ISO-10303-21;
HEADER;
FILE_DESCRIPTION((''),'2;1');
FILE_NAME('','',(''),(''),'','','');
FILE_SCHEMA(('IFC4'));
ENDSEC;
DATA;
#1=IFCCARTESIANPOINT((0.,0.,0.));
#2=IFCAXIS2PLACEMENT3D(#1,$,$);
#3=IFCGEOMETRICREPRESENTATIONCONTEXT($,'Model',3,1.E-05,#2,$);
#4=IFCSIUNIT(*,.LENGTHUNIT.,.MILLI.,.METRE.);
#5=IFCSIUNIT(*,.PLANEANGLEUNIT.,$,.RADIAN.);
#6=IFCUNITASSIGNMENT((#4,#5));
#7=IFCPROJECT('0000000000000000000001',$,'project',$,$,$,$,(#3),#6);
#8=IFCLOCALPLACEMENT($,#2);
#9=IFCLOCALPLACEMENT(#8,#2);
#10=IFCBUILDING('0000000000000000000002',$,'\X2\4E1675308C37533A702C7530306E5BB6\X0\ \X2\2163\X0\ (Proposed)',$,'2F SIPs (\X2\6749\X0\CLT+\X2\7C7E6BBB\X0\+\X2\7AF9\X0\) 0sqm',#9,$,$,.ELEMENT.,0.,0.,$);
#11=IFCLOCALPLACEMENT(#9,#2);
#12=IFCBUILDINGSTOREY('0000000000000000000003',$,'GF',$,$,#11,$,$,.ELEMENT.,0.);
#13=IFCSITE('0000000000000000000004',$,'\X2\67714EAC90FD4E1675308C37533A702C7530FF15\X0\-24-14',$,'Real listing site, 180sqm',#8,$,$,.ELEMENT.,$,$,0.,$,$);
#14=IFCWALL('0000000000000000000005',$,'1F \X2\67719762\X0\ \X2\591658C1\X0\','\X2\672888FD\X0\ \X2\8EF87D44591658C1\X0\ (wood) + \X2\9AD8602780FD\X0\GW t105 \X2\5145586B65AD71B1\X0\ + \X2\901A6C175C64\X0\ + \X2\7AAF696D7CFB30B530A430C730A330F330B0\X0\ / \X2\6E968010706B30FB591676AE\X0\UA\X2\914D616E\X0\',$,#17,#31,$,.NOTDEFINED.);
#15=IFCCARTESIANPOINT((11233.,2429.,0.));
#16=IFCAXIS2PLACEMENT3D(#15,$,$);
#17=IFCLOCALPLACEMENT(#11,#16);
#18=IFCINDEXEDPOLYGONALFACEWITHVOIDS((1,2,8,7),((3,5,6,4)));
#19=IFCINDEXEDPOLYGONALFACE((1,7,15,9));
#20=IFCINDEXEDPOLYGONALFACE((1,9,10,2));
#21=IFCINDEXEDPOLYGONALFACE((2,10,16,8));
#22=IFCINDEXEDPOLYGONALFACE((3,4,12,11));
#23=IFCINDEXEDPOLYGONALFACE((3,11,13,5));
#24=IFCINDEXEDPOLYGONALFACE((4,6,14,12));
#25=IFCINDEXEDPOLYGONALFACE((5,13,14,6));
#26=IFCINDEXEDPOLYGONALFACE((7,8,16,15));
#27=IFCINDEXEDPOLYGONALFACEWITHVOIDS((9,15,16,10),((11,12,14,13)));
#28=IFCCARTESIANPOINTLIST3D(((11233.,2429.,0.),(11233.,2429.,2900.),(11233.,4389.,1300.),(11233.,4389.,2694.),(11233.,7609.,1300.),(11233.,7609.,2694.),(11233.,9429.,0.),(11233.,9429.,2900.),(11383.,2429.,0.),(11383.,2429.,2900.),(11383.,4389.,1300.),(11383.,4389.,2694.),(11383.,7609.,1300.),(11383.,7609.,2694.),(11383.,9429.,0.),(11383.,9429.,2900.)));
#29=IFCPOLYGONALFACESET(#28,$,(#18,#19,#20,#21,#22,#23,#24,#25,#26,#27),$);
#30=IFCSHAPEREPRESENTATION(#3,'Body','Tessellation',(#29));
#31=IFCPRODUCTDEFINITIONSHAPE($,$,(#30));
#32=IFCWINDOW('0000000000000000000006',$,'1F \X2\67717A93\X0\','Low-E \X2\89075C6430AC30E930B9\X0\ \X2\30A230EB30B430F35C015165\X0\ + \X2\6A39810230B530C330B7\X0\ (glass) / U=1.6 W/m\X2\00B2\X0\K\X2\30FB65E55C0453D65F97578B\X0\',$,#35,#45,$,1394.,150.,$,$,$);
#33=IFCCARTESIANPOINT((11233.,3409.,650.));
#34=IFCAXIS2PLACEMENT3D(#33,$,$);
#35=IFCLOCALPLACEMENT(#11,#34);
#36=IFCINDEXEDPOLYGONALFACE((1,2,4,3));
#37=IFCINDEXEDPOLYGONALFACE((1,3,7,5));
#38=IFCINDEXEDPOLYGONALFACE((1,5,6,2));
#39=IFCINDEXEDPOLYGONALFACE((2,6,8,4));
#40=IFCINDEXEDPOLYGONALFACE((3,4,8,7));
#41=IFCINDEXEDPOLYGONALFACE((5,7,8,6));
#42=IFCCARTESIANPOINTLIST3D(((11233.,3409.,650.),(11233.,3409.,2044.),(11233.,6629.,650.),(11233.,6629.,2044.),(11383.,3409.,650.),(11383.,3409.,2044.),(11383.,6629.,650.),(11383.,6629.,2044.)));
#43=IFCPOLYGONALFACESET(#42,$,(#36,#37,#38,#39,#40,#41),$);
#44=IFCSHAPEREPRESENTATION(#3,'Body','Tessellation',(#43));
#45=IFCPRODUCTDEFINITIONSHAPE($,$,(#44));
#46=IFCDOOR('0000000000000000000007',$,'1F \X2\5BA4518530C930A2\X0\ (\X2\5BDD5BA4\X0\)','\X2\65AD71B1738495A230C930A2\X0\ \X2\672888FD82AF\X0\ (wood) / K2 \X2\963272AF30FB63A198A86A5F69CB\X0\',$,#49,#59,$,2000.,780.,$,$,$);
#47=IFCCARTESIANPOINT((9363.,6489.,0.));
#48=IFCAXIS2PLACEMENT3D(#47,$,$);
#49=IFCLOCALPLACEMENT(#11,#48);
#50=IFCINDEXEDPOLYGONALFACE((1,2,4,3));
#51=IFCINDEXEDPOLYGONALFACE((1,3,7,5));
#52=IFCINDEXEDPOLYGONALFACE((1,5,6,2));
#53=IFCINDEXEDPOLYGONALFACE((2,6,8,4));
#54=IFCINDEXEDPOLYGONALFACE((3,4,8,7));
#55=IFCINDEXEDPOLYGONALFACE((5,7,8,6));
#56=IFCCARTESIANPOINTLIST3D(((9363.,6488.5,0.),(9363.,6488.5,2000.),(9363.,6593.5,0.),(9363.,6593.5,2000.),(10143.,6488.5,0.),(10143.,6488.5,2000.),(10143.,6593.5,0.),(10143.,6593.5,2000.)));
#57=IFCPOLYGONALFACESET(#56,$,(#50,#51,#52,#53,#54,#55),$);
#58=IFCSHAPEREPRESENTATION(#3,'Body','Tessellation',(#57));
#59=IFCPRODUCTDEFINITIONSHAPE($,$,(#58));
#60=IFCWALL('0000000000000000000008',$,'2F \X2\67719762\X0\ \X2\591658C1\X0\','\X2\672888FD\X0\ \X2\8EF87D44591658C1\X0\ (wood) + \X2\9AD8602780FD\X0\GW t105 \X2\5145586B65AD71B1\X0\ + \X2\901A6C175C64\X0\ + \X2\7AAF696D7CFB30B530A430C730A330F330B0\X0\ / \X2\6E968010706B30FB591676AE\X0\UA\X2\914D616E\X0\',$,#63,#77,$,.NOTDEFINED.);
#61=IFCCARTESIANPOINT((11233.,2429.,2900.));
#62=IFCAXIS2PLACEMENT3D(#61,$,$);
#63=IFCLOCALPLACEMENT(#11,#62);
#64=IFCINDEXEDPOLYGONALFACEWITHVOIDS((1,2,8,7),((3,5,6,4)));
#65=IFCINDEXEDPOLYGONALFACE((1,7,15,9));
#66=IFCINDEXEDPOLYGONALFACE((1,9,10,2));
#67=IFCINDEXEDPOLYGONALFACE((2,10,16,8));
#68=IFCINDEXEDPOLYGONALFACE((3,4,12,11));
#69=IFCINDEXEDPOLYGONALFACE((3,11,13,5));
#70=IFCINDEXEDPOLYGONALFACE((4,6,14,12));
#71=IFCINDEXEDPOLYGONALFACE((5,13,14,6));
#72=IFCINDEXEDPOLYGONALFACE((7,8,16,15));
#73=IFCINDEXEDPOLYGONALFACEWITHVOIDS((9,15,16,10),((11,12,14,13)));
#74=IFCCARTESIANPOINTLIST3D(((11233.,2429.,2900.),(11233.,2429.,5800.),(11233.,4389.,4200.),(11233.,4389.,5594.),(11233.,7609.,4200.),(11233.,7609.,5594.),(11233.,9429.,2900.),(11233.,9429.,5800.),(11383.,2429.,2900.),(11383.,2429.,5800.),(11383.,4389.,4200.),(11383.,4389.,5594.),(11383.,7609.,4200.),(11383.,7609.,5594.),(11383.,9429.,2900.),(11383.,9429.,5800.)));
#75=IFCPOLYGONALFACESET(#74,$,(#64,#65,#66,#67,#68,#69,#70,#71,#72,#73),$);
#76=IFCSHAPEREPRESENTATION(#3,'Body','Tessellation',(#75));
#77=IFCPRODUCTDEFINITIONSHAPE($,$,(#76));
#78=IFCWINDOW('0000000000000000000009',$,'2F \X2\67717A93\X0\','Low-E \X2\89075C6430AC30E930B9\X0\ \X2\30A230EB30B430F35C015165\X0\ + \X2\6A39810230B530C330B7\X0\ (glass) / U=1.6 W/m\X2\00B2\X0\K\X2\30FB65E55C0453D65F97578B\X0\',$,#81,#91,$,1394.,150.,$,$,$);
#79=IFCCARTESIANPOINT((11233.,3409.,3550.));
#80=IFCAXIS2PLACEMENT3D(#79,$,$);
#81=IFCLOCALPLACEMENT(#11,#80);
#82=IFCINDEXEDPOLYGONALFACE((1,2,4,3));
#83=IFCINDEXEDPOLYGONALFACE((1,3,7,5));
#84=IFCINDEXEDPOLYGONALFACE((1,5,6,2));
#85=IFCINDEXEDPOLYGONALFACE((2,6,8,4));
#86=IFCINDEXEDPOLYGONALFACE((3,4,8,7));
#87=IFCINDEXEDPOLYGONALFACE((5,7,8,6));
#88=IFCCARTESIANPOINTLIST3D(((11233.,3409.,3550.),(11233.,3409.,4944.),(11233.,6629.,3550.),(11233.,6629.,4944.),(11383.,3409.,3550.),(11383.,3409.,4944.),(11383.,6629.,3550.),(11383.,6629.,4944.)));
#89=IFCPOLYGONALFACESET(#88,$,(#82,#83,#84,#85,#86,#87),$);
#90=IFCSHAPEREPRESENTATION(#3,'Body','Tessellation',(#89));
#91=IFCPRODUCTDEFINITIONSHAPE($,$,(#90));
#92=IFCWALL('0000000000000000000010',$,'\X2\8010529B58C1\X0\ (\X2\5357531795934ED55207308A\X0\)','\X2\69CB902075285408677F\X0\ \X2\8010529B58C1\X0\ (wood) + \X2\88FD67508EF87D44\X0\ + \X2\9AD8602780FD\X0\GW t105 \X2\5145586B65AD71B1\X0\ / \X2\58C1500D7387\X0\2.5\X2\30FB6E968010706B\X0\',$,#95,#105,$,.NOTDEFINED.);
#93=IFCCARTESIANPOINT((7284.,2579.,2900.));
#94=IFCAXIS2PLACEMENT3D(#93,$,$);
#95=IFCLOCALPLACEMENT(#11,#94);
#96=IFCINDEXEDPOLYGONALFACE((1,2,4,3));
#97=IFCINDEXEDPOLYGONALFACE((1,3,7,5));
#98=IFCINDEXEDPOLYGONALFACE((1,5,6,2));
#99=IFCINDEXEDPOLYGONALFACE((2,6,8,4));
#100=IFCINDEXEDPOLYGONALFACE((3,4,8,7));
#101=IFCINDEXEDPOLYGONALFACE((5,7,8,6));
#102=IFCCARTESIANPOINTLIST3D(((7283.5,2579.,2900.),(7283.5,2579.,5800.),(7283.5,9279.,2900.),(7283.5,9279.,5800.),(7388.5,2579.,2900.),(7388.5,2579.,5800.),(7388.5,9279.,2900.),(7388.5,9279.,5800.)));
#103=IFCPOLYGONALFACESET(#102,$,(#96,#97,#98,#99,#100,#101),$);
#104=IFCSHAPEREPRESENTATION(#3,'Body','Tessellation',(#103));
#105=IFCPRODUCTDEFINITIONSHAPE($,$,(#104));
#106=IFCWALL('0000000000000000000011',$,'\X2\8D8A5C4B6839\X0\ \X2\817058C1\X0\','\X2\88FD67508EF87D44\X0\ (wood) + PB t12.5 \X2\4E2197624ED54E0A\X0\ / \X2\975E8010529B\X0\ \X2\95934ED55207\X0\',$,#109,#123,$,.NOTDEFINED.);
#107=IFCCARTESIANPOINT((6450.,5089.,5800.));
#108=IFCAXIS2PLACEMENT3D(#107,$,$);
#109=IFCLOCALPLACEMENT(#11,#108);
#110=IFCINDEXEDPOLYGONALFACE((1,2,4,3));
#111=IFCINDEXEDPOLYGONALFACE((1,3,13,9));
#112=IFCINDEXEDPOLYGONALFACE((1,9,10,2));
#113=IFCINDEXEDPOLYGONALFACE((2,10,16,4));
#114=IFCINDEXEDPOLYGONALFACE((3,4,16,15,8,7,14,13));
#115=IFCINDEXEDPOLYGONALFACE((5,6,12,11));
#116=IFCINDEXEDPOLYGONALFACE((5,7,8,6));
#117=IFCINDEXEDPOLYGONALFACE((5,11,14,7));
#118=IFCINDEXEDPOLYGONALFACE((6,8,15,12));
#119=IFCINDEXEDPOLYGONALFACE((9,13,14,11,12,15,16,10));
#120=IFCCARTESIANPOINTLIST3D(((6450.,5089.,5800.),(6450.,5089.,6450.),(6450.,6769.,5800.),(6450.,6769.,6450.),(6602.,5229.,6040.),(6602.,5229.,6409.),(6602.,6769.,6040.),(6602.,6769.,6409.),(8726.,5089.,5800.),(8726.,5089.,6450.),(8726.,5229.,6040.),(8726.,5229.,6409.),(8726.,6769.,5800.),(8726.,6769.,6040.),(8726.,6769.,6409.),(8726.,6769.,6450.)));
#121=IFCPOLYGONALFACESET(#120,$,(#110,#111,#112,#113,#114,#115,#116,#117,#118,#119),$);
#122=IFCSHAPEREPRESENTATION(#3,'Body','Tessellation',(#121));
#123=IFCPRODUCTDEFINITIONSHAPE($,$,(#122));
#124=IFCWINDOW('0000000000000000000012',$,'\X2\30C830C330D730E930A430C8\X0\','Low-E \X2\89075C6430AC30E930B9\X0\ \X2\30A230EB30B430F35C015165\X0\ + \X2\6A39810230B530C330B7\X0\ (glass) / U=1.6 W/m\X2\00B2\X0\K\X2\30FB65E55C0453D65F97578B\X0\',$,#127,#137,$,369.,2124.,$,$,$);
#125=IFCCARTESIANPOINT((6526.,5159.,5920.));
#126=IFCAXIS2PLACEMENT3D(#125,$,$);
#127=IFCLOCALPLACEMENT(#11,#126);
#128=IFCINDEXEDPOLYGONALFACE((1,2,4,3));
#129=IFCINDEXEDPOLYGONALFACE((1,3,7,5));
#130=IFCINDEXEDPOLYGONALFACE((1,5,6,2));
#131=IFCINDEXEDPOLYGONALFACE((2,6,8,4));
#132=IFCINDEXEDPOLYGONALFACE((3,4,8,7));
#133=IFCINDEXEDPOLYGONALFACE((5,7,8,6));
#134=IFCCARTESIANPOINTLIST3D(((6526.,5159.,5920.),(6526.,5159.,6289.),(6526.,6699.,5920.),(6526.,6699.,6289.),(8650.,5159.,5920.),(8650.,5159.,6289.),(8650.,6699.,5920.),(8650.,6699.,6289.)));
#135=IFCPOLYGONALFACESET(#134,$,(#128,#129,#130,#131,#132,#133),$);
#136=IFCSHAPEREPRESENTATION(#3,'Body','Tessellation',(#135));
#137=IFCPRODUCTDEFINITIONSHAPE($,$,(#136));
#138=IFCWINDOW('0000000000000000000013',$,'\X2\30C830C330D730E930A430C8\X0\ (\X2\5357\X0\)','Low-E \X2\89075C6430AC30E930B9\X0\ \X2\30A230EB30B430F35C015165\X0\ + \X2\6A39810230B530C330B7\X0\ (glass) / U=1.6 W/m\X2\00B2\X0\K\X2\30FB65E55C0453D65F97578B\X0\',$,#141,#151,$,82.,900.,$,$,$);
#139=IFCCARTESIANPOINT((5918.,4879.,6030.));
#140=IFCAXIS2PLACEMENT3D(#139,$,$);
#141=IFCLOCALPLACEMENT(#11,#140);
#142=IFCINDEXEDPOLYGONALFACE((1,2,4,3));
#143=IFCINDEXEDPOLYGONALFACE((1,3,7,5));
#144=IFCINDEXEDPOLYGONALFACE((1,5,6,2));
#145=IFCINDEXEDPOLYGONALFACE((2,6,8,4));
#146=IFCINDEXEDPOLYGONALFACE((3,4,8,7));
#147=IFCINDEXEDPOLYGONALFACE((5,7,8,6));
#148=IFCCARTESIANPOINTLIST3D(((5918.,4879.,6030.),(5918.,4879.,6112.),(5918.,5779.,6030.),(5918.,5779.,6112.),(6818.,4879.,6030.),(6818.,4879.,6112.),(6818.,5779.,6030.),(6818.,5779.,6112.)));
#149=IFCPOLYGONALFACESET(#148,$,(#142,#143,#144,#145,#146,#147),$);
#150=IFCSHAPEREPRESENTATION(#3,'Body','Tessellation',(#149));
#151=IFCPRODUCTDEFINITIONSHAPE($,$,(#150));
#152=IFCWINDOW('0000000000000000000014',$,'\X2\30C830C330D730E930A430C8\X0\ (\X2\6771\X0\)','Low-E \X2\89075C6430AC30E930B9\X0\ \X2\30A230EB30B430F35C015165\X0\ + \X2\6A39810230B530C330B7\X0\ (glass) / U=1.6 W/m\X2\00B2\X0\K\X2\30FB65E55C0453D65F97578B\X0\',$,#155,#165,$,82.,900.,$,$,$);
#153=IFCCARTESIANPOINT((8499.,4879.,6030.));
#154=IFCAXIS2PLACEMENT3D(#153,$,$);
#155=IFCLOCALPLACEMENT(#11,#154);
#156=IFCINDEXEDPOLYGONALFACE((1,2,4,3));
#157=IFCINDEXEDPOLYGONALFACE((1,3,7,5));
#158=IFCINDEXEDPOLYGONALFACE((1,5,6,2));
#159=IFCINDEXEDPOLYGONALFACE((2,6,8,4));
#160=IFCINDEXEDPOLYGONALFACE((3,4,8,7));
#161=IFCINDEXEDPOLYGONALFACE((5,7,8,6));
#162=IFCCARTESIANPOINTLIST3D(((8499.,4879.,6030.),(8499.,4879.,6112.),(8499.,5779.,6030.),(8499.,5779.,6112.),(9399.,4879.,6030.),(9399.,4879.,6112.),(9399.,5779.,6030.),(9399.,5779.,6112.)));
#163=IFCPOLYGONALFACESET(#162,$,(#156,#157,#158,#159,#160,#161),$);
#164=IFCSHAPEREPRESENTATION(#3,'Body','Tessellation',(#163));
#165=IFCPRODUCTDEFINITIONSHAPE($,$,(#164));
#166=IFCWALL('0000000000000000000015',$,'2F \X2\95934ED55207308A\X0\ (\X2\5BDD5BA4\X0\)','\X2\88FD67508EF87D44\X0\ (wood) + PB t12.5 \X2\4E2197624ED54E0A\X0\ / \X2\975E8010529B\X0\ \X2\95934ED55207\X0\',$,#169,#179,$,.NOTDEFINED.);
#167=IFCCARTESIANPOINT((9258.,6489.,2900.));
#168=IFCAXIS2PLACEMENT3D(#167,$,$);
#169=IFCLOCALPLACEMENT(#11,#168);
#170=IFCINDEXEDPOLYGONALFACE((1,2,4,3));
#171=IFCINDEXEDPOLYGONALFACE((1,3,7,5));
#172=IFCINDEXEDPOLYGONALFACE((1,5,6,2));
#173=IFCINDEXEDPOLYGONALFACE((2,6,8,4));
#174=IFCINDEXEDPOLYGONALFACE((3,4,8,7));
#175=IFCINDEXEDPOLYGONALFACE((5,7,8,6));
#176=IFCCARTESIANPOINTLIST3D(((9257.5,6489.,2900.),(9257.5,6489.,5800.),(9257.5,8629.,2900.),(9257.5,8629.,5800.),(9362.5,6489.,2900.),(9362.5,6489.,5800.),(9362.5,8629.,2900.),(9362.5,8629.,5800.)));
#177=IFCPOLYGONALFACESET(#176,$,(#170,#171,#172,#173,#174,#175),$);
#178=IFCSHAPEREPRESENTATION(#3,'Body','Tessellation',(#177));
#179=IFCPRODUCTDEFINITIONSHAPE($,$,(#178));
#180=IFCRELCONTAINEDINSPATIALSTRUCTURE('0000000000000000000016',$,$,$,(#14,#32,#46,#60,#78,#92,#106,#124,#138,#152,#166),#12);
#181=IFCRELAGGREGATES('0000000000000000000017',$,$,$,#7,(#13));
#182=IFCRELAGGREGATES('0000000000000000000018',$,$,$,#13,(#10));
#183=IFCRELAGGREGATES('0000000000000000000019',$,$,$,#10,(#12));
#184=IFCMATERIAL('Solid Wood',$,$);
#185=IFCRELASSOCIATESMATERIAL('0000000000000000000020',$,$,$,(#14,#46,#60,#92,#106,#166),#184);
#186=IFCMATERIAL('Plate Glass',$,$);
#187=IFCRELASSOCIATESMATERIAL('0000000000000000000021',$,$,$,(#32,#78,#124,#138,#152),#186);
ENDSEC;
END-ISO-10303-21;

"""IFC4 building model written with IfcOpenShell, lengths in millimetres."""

from ifc_helpers import new_model, si_unit, frame, frame_2d, origin, place, context, project, spatial, rectangle, extrude, material, element, fill, save


model = new_model("IFC4")

# Units and contexts
model_context = context("Model", 3, precision=1e-05, world=origin())
ifc_project = project(units=[si_unit("LENGTHUNIT", "METRE", prefix="MILLI"), si_unit("PLANEANGLEUNIT", "RADIAN")], contexts=[model_context])

# Site, building, storey
site_placement = place(None, origin())
site = spatial("IfcSite", under=ifc_project, at=site_placement, Name="東京都世田谷区瀬田５-24-14", ObjectType="Real listing site, 180sqm", CompositionType="ELEMENT", RefElevation=0.0)
building_placement = place(site_placement, origin())
building = spatial("IfcBuilding", under=site, at=building_placement, Name="世田谷区瀬田の家 Ⅳ (Proposed)", ObjectType="2F SIPs (杉CLT+籾殻+竹) 0sqm", CompositionType="ELEMENT", ElevationOfRefHeight=0.0, ElevationOfTerrain=0.0)
storey_placement = place(building_placement, origin())
storey = spatial("IfcBuildingStorey", under=building, at=storey_placement, Name="GF", CompositionType="ELEMENT", Elevation=0.0)

# Wall, opening, window
ifc_material_1 = material(Name="Solid Wood")
wall_1_placement = place(storey_placement, frame((11233.0, 2429.0, 0.0)))
wall_1 = element("IfcWall", 1, at=wall_1_placement, inside=storey, material=ifc_material_1, Name="1F 東面 外壁", Description="木製 軸組外壁 (wood) + 高性能GW t105 充填断熱 + 通気層 + 窯業系サイディング / 準耐火・外皮UA配慮", PredefinedType="NOTDEFINED", context=model_context, shape_type="SweptSolid", body=[
    extrude(rectangle(XDim=150.0, YDim=7000.0, at=frame_2d((75.0, 3500.0))), frame((11233.0, 2429.0, 0.0)), (0.0, 0.0, 1.0), 2900.0),
])
opening_1_placement = place(storey_placement, frame((11233.0, 3409.0, 650.0)))
opening_1 = element("IfcOpeningElement", 2, at=opening_1_placement, cuts=wall_1, PredefinedType="NOTDEFINED", context=model_context, shape_type="SweptSolid", body=[
    extrude(rectangle(XDim=150.0, YDim=3220.0, at=frame_2d((75.0, 1610.0))), frame((11233.0, 3409.0, 650.0)), (0.0, 0.0, 1.0), 1394.0),
])
ifc_material_2 = material(Name="Plate Glass")
window_1_placement = place(storey_placement, frame((11233.0, 3409.0, 650.0)))
window_1 = element("IfcWindow", 3, at=window_1_placement, inside=storey, material=ifc_material_2, Name="1F 東窓", Description="Low-E 複層ガラス アルゴン封入 + 樹脂サッシ (glass) / U=1.6 W/m²K・日射取得型", OverallHeight=1394.0, OverallWidth=150.0, context=model_context, shape_type="SweptSolid", body=[
    extrude(rectangle(XDim=150.0, YDim=3220.0, at=frame_2d((75.0, 1610.0))), frame((11233.0, 3409.0, 650.0)), (0.0, 0.0, 1.0), 1394.0),
])
fill(opening_1, window_1)

# Door
door_1_placement = place(storey_placement, frame((9363.0, 6489.0, 0.0)))
element("IfcDoor", 4, at=door_1_placement, inside=storey, material=ifc_material_1, Name="1F 室内ドア (寝室)", Description="断熱玄関ドア 木製芯 (wood) / K2 防犯・採風機構", OverallHeight=2000.0, OverallWidth=780.0, context=model_context, shape_type="SweptSolid", body=[
    extrude(rectangle(XDim=780.0, YDim=105.0, at=frame_2d((390.0, 52.0))), frame((9363.0, 6489.0, 0.0)), (0.0, 0.0, 1.0), 2000.0),
])

# Wall, opening, window
wall_2_placement = place(storey_placement, frame((11233.0, 2429.0, 2900.0)))
wall_2 = element("IfcWall", 5, at=wall_2_placement, inside=storey, material=ifc_material_1, Name="2F 東面 外壁", Description="木製 軸組外壁 (wood) + 高性能GW t105 充填断熱 + 通気層 + 窯業系サイディング / 準耐火・外皮UA配慮", PredefinedType="NOTDEFINED", context=model_context, shape_type="SweptSolid", body=[
    extrude(rectangle(XDim=150.0, YDim=7000.0, at=frame_2d((75.0, 3500.0))), frame((11233.0, 2429.0, 2900.0)), (0.0, 0.0, 1.0), 2900.0),
])
opening_2_placement = place(storey_placement, frame((11233.0, 3409.0, 3550.0)))
opening_2 = element("IfcOpeningElement", 6, at=opening_2_placement, cuts=wall_2, PredefinedType="NOTDEFINED", context=model_context, shape_type="SweptSolid", body=[
    extrude(rectangle(XDim=150.0, YDim=3220.0, at=frame_2d((75.0, 1610.0))), frame((11233.0, 3409.0, 3550.0)), (0.0, 0.0, 1.0), 1394.0),
])
window_2_placement = place(storey_placement, frame((11233.0, 3409.0, 3550.0)))
window_2 = element("IfcWindow", 7, at=window_2_placement, inside=storey, material=ifc_material_2, Name="2F 東窓", Description="Low-E 複層ガラス アルゴン封入 + 樹脂サッシ (glass) / U=1.6 W/m²K・日射取得型", OverallHeight=1394.0, OverallWidth=150.0, context=model_context, shape_type="SweptSolid", body=[
    extrude(rectangle(XDim=150.0, YDim=3220.0, at=frame_2d((75.0, 1610.0))), frame((11233.0, 3409.0, 3550.0)), (0.0, 0.0, 1.0), 1394.0),
])
fill(opening_2, window_2)

# Wall
wall_3_placement = place(storey_placement, frame((7284.0, 2579.0, 2900.0)))
element("IfcWall", 8, at=wall_3_placement, inside=storey, material=ifc_material_1, Name="耐力壁 (南北間仕切り)", Description="構造用合板 耐力壁 (wood) + 製材軸組 + 高性能GW t105 充填断熱 / 壁倍率2.5・準耐火", PredefinedType="NOTDEFINED", context=model_context, shape_type="SweptSolid", body=[
    extrude(rectangle(XDim=105.0, YDim=6700.0, at=frame_2d((52.0, 3350.0))), frame((7284.0, 2579.0, 2900.0)), (0.0, 0.0, 1.0), 2900.0),
])

# Wall, openings, windows
wall_4_placement = place(storey_placement, frame((6450.0, 5089.0, 5800.0)))
wall_4 = element("IfcWall", 9, at=wall_4_placement, inside=storey, material=ifc_material_1, Name="越屋根 腰壁", Description="製材軸組 (wood) + PB t12.5 両面仕上 / 非耐力 間仕切", PredefinedType="NOTDEFINED", context=model_context, shape_type="SweptSolid", body=[
    extrude(rectangle(XDim=2276.0, YDim=1680.0, at=frame_2d((1138.0, 840.0))), frame((6450.0, 5089.0, 5800.0)), (0.0, 0.0, 1.0), 650.0),
])
opening_3_placement = place(storey_placement, frame((6526.0, 5159.0, 5920.0)))
opening_3 = element("IfcOpeningElement", 10, at=opening_3_placement, cuts=wall_4, PredefinedType="NOTDEFINED", context=model_context, shape_type="SweptSolid", body=[
    extrude(rectangle(XDim=2124.0, YDim=1540.0, at=frame_2d((1062.0, 770.0))), frame((6526.0, 5159.0, 5920.0)), (0.0, 0.0, 1.0), 369.0),
])
opening_4_placement = place(storey_placement, frame((5918.0, 4879.0, 6030.0)))
opening_4 = element("IfcOpeningElement", 11, at=opening_4_placement, cuts=wall_4, PredefinedType="NOTDEFINED", context=model_context, shape_type="SweptSolid", body=[
    extrude(rectangle(XDim=900.0, YDim=900.0, at=frame_2d((450.0, 450.0))), frame((5918.0, 4879.0, 6030.0)), (0.0, 0.0, 1.0), 82.0),
])
opening_5_placement = place(storey_placement, frame((8499.0, 4879.0, 6030.0)))
opening_5 = element("IfcOpeningElement", 12, at=opening_5_placement, cuts=wall_4, PredefinedType="NOTDEFINED", context=model_context, shape_type="SweptSolid", body=[
    extrude(rectangle(XDim=900.0, YDim=900.0, at=frame_2d((450.0, 450.0))), frame((8499.0, 4879.0, 6030.0)), (0.0, 0.0, 1.0), 82.0),
])
window_3_placement = place(storey_placement, frame((6526.0, 5159.0, 5920.0)))
window_3 = element("IfcWindow", 13, at=window_3_placement, inside=storey, material=ifc_material_2, Name="トップライト", Description="Low-E 複層ガラス アルゴン封入 + 樹脂サッシ (glass) / U=1.6 W/m²K・日射取得型", OverallHeight=369.0, OverallWidth=2124.0, context=model_context, shape_type="SweptSolid", body=[
    extrude(rectangle(XDim=2124.0, YDim=1540.0, at=frame_2d((1062.0, 770.0))), frame((6526.0, 5159.0, 5920.0)), (0.0, 0.0, 1.0), 369.0),
])
fill(opening_3, window_3)
window_4_placement = place(storey_placement, frame((5918.0, 4879.0, 6030.0)))
window_4 = element("IfcWindow", 14, at=window_4_placement, inside=storey, material=ifc_material_2, Name="トップライト (南)", Description="Low-E 複層ガラス アルゴン封入 + 樹脂サッシ (glass) / U=1.6 W/m²K・日射取得型", OverallHeight=82.0, OverallWidth=900.0, context=model_context, shape_type="SweptSolid", body=[
    extrude(rectangle(XDim=900.0, YDim=900.0, at=frame_2d((450.0, 450.0))), frame((5918.0, 4879.0, 6030.0)), (0.0, 0.0, 1.0), 82.0),
])
fill(opening_4, window_4)
window_5_placement = place(storey_placement, frame((8499.0, 4879.0, 6030.0)))
window_5 = element("IfcWindow", 15, at=window_5_placement, inside=storey, material=ifc_material_2, Name="トップライト (東)", Description="Low-E 複層ガラス アルゴン封入 + 樹脂サッシ (glass) / U=1.6 W/m²K・日射取得型", OverallHeight=82.0, OverallWidth=900.0, context=model_context, shape_type="SweptSolid", body=[
    extrude(rectangle(XDim=900.0, YDim=900.0, at=frame_2d((450.0, 450.0))), frame((8499.0, 4879.0, 6030.0)), (0.0, 0.0, 1.0), 82.0),
])
fill(opening_5, window_5)

# Wall
wall_5_placement = place(storey_placement, frame((9258.0, 6489.0, 2900.0)))
element("IfcWall", 16, at=wall_5_placement, inside=storey, material=ifc_material_1, Name="2F 間仕切り (寝室)", Description="製材軸組 (wood) + PB t12.5 両面仕上 / 非耐力 間仕切", PredefinedType="NOTDEFINED", context=model_context, shape_type="SweptSolid", body=[
    extrude(rectangle(XDim=105.0, YDim=2140.0, at=frame_2d((52.0, 1070.0))), frame((9258.0, 6489.0, 2900.0)), (0.0, 0.0, 1.0), 2900.0),
])

save(model, "model.ifc")
